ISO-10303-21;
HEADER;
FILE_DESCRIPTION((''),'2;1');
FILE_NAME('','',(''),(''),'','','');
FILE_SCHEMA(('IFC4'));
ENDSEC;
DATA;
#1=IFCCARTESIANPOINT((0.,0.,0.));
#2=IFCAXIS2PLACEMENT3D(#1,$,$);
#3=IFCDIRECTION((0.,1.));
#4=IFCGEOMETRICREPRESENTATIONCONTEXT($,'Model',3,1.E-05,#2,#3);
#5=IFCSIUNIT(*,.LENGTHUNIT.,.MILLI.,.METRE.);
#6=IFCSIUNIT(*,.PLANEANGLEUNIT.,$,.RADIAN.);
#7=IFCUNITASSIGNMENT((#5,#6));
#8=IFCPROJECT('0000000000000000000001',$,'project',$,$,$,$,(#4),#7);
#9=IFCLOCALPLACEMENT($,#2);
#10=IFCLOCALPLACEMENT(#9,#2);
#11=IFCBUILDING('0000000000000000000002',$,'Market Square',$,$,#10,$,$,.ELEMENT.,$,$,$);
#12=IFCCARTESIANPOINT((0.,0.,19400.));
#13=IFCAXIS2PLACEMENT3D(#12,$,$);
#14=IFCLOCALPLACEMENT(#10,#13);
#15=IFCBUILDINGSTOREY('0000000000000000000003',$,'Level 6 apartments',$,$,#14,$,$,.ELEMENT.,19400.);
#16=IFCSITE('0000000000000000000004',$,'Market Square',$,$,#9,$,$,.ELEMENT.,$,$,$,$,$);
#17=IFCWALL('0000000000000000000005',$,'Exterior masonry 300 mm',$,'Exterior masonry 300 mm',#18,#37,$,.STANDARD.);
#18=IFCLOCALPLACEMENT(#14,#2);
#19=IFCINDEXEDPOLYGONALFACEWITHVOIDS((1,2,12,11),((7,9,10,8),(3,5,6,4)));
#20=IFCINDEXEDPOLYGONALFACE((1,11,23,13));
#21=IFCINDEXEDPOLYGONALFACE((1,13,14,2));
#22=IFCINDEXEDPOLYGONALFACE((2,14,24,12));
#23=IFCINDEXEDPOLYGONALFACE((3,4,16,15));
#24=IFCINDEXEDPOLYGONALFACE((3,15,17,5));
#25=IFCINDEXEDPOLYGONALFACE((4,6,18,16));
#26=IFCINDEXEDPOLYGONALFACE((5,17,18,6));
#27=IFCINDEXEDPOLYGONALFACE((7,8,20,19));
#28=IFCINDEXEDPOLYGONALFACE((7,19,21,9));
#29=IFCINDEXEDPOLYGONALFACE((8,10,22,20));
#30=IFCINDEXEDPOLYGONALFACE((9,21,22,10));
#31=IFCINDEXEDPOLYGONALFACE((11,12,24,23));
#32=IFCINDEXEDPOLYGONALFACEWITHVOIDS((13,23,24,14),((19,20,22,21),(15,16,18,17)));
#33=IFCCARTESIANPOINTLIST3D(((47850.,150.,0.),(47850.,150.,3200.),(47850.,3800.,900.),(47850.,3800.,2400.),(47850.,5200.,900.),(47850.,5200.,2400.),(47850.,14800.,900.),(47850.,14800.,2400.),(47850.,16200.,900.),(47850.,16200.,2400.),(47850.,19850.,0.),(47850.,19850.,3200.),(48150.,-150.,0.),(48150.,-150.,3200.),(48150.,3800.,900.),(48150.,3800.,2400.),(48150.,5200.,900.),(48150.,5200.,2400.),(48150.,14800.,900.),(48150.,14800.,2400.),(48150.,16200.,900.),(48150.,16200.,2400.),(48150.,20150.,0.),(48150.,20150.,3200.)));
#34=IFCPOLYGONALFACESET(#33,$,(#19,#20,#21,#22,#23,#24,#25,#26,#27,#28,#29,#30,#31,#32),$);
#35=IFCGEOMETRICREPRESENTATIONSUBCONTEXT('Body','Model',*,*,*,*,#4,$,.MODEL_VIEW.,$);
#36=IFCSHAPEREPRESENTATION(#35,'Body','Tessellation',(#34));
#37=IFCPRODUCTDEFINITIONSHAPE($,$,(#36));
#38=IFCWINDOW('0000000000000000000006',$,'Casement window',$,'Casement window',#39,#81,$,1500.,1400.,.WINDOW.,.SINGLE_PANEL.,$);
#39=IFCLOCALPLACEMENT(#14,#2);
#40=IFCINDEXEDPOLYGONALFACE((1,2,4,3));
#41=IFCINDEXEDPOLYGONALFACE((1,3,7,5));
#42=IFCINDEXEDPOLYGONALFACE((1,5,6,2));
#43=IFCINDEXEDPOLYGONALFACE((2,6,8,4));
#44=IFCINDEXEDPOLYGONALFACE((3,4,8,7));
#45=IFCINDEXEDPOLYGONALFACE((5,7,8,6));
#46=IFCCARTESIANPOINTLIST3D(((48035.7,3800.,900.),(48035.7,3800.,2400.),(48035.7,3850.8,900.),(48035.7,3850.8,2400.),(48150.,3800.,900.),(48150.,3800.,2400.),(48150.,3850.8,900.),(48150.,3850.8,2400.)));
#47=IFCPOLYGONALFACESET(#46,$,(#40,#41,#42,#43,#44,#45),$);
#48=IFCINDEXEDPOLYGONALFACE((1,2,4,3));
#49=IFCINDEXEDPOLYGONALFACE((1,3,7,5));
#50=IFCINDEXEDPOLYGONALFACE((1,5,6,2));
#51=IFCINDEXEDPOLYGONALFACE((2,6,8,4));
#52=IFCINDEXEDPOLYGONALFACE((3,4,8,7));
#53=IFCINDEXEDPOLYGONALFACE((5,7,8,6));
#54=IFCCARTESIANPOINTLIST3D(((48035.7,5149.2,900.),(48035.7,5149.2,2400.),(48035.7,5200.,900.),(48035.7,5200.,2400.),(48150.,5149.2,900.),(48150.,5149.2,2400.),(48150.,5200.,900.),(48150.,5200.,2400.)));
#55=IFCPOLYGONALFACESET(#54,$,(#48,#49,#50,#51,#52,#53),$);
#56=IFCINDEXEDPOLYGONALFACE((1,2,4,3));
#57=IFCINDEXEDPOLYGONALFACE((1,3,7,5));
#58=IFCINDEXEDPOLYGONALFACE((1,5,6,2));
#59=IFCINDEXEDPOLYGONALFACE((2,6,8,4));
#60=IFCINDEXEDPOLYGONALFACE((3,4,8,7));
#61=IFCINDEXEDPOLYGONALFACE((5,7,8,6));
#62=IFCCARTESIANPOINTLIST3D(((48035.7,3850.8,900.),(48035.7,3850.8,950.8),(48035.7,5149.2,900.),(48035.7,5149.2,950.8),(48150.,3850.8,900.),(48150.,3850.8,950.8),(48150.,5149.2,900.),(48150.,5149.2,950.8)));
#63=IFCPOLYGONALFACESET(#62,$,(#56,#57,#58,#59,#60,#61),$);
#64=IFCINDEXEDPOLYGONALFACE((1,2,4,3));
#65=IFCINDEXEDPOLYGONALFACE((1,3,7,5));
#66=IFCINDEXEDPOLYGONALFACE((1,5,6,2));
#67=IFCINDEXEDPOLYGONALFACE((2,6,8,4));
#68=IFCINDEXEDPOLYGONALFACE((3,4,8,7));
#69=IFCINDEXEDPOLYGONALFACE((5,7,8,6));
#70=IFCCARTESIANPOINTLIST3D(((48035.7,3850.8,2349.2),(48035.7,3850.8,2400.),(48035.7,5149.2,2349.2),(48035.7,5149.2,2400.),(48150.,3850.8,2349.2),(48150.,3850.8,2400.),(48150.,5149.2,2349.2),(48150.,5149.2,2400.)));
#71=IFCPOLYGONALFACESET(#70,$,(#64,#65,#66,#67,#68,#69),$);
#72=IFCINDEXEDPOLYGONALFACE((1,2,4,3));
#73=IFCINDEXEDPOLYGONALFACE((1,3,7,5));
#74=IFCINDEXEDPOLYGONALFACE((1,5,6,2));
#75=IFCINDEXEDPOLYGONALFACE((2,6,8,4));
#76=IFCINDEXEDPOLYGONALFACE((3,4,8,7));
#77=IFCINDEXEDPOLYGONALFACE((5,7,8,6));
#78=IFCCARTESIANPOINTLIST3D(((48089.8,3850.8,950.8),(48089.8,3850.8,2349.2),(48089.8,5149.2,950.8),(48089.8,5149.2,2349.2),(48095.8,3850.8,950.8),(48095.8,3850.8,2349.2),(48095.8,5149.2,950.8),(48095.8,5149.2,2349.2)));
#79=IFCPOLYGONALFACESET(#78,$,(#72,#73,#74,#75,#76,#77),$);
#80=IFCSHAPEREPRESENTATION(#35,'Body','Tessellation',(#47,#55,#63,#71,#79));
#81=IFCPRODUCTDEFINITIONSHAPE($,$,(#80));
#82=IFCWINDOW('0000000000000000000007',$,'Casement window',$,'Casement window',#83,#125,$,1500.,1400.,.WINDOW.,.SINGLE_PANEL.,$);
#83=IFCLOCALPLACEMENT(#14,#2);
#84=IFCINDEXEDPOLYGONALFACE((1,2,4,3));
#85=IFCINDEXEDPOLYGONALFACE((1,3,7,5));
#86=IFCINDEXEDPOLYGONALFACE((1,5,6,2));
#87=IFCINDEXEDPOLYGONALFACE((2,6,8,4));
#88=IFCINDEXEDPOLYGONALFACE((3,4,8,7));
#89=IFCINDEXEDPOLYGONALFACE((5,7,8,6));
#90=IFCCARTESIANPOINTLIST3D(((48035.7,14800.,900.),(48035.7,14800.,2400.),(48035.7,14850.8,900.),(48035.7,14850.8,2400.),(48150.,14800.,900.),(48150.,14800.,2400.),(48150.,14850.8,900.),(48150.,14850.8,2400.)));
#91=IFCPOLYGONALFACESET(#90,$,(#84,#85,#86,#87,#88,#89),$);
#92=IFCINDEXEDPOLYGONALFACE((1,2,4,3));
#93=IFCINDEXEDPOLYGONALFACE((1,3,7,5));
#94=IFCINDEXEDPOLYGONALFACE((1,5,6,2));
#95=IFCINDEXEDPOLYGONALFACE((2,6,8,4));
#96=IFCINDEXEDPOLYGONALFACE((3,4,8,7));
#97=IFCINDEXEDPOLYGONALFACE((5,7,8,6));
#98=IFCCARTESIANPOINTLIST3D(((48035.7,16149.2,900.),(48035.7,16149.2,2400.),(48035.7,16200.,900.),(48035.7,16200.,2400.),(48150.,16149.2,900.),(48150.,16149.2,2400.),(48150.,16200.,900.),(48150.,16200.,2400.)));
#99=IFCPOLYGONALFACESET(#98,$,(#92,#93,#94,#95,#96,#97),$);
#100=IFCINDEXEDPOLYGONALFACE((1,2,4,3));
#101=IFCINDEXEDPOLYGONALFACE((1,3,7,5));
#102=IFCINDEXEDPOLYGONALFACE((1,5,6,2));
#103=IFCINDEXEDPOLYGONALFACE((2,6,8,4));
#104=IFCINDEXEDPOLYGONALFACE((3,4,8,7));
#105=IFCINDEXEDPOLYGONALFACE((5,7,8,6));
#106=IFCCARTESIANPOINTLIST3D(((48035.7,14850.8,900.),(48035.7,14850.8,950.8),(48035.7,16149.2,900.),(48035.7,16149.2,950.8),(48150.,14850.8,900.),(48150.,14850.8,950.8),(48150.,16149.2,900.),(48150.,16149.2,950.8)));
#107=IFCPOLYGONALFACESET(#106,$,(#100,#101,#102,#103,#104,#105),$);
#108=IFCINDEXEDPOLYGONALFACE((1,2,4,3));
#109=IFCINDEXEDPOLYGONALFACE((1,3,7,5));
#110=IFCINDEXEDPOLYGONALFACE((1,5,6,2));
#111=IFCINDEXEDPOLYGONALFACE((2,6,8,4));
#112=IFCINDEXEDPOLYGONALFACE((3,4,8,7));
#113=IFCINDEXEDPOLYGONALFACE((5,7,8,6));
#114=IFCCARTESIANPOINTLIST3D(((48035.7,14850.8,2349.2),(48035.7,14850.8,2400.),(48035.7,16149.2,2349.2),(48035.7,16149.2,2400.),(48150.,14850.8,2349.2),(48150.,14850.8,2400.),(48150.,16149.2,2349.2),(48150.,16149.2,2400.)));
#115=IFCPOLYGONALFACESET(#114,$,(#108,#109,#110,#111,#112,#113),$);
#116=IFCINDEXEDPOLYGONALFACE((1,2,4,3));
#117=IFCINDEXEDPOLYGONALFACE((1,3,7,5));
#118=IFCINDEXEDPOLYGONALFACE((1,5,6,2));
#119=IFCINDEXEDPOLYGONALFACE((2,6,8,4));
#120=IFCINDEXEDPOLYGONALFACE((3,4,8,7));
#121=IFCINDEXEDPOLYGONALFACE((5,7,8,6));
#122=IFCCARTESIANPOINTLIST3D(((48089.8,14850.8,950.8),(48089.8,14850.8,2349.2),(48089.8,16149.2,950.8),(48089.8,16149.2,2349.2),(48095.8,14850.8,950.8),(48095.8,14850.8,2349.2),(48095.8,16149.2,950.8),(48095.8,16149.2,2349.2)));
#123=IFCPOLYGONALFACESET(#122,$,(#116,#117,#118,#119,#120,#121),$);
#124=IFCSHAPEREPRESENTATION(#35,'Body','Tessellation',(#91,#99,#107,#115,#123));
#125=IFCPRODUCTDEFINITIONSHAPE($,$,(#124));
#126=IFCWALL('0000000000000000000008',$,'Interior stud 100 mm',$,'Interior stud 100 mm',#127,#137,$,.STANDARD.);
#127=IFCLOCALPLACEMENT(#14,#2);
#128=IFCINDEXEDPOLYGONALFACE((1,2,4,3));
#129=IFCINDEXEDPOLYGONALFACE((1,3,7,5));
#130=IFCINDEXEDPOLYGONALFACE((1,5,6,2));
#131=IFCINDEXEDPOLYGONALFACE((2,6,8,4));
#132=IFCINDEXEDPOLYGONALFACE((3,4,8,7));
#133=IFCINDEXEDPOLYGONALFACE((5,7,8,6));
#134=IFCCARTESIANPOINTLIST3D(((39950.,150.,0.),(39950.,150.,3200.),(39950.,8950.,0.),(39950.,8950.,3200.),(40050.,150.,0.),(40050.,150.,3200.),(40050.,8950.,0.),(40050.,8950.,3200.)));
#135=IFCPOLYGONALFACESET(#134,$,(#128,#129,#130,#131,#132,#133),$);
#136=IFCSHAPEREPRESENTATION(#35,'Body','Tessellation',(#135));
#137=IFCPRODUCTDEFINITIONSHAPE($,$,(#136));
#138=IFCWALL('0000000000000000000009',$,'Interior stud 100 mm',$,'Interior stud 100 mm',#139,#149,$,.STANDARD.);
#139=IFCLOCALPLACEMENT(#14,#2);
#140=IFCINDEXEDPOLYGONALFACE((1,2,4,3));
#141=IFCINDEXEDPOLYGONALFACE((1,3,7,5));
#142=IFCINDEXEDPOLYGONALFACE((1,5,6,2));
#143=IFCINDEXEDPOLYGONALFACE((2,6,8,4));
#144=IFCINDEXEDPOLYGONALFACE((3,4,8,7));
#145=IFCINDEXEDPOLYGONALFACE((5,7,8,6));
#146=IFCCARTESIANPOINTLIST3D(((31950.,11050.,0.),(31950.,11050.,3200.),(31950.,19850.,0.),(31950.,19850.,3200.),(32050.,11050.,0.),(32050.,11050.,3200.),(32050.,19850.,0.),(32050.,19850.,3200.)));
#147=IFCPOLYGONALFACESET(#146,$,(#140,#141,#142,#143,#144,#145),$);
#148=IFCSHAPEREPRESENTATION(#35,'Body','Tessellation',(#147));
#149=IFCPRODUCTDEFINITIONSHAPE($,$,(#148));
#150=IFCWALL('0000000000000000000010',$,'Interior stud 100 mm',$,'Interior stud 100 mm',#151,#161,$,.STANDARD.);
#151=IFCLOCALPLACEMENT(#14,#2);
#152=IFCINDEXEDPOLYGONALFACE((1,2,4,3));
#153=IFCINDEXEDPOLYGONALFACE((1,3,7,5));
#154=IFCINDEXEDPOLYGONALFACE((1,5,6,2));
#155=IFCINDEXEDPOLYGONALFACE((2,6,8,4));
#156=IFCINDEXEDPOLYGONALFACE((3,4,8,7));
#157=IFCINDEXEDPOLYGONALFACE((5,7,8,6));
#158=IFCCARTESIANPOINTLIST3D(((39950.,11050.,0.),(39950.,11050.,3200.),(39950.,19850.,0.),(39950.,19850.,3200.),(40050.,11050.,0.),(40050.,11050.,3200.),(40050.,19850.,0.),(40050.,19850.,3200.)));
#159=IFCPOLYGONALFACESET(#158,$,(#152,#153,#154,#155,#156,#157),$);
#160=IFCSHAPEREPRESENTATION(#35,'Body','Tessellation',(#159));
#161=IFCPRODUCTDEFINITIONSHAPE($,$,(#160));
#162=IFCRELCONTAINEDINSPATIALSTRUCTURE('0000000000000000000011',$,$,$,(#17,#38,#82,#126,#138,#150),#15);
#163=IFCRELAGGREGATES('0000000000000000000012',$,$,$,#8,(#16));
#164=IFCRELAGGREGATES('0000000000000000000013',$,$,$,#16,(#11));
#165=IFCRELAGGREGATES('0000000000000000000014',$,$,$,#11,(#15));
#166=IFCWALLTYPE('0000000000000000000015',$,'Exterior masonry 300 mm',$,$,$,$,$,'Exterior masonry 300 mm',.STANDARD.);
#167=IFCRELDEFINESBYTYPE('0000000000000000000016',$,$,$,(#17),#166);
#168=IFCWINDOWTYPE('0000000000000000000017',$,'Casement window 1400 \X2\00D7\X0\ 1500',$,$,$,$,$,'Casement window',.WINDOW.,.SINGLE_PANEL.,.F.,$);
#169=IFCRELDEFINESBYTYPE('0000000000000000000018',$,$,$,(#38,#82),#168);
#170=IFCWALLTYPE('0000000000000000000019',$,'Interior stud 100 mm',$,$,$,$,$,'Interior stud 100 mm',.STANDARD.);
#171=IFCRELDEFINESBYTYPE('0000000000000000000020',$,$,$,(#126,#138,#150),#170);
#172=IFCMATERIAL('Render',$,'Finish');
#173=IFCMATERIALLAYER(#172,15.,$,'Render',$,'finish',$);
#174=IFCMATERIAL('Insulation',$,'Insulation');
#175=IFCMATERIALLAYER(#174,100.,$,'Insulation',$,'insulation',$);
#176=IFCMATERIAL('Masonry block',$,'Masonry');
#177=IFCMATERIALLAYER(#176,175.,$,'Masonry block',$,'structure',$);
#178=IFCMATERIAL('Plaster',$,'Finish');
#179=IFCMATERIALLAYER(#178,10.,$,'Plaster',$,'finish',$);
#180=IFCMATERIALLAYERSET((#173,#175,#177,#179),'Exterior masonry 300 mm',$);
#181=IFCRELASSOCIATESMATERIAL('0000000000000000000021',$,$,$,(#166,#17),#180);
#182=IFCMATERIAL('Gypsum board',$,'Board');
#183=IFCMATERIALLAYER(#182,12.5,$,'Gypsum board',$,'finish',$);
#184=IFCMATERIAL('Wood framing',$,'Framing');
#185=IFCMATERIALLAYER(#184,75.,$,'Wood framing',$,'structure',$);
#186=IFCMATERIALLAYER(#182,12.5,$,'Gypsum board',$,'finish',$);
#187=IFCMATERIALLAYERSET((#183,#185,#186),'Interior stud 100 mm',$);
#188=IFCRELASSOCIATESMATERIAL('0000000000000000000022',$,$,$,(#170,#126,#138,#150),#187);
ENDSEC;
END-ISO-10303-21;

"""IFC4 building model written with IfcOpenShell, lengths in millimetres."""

from ifc_helpers import new_model, si_unit, direction, frame, origin, origin_with_axes, place, context, subcontext, project, spatial, polyline, outline, extrude, material, layer, layer_set, layer_usage, type_object, element, fill, save


model = new_model("IFC4")

# Units and contexts
model_context = context("Model", 3, precision=1e-05, world=origin(), true_north=direction((0.0, 1.0)))
body_context = subcontext(model_context, "Body", "Model", "MODEL_VIEW")
ifc_project = project(units=[si_unit("LENGTHUNIT", "METRE", prefix="MILLI"), si_unit("PLANEANGLEUNIT", "RADIAN")], contexts=[model_context])

# Site, building, storey
site_placement = place(None, origin())
site = spatial("IfcSite", under=ifc_project, at=site_placement, Name="Market Square", CompositionType="ELEMENT")
building_placement = place(site_placement, origin())
building = spatial("IfcBuilding", under=site, at=building_placement, Name="Market Square", CompositionType="ELEMENT")
storey_placement = place(building_placement, frame((0.0, 0.0, 19400.0)))
storey = spatial("IfcBuildingStorey", under=building, at=storey_placement, Name="Level 6 apartments", CompositionType="ELEMENT", Elevation=19400.0)

# Wall, openings, windows
ifc_material_1 = material(Name="Render", Category="Finish")
ifc_layer_1 = layer(ifc_material_1, 15.0, Name="Render", Category="finish")
ifc_material_2 = material(Name="Insulation", Category="Insulation")
ifc_layer_2 = layer(ifc_material_2, 100.0, Name="Insulation", Category="insulation")
ifc_material_3 = material(Name="Masonry block", Category="Masonry")
ifc_layer_3 = layer(ifc_material_3, 175.0, Name="Masonry block", Category="structure")
ifc_material_4 = material(Name="Plaster", Category="Finish")
ifc_layer_4 = layer(ifc_material_4, 10.0, Name="Plaster", Category="finish")
ifc_layer_set_1 = layer_set([ifc_layer_1, ifc_layer_2, ifc_layer_3, ifc_layer_4], Name="Exterior masonry 300 mm")
ifc_layer_usage_1 = layer_usage(ifc_layer_set_1, "AXIS2", "POSITIVE", -150.0)
wall_type_1 = type_object("IfcWallType", Name="Exterior masonry 300 mm", ElementType="Exterior masonry 300 mm", PredefinedType="STANDARD", material=ifc_layer_set_1)
wall_1_placement = place(storey_placement, frame((48000.0, 0.0, 0.0), z_axis=(0.0, 0.0, 1.0), x_axis=(0.0, 1.0, 0.0)))
wall_1 = element("IfcWall", 1, at=wall_1_placement, inside=storey, type_object=wall_type_1, material=ifc_layer_usage_1, Name="Exterior masonry 300 mm", ObjectType="Exterior masonry 300 mm", PredefinedType="STANDARD", context=body_context, shape_type="SweptSolid", body=[
    extrude(outline(polyline([(-150.0, -150.0), (20150.0, -150.0), (19850.0, 150.0), (150.0, 150.0), (-150.0, -150.0)])), origin(), (0.0, 0.0, 1.0), 3200.0),
])
opening_1_placement = place(wall_1_placement, frame((3800.0, 0.0, 900.0), z_axis=(0.0, 0.0, 1.0), x_axis=(1.0, 0.0, 0.0)))
opening_1 = element("IfcOpeningElement", 2, at=opening_1_placement, cuts=wall_1, PredefinedType="OPENING", context=body_context, shape_type="SweptSolid", body=[
    extrude(outline(polyline([(0.0, -160.0), (1400.0, -160.0), (1400.0, 160.0), (0.0, 160.0), (0.0, -160.0)])), origin(), (0.0, 0.0, 1.0), 1500.0),
])
opening_2_placement = place(wall_1_placement, frame((14800.0, 0.0, 900.0), z_axis=(0.0, 0.0, 1.0), x_axis=(1.0, 0.0, 0.0)))
opening_2 = element("IfcOpeningElement", 3, at=opening_2_placement, cuts=wall_1, PredefinedType="OPENING", context=body_context, shape_type="SweptSolid", body=[
    extrude(outline(polyline([(0.0, -160.0), (1400.0, -160.0), (1400.0, 160.0), (0.0, 160.0), (0.0, -160.0)])), origin(), (0.0, 0.0, 1.0), 1500.0),
])
window_type = type_object("IfcWindowType", Name="Casement window 1400 × 1500", ElementType="Casement window", ParameterTakesPrecedence=False, PartitioningType="SINGLE_PANEL", PredefinedType="WINDOW")
window_1_placement = place(opening_1_placement, origin_with_axes())
window_1 = element("IfcWindow", 4, at=window_1_placement, inside=storey, type_object=window_type, Name="Casement window", ObjectType="Casement window", OverallHeight=1500.0, OverallWidth=1400.0, PartitioningType="SINGLE_PANEL", PredefinedType="WINDOW", context=body_context, shape_type="SweptSolid", body=[
    extrude(outline(polyline([(0.0, -150.0), (50.8, -150.0), (50.8, -35.7), (0.0, -35.7), (0.0, -150.0)])), origin(), (0.0, 0.0, 1.0), 1500.0),
    extrude(outline(polyline([(1349.2, -150.0), (1400.0, -150.0), (1400.0, -35.7), (1349.2, -35.7), (1349.2, -150.0)])), origin(), (0.0, 0.0, 1.0), 1500.0),
    extrude(outline(polyline([(50.8, -150.0), (1349.2, -150.0), (1349.2, -35.7), (50.8, -35.7), (50.8, -150.0)])), origin(), (0.0, 0.0, 1.0), 50.8),
    extrude(outline(polyline([(50.8, -150.0), (1349.2, -150.0), (1349.2, -35.7), (50.8, -35.7), (50.8, -150.0)])), frame((0.0, 0.0, 1449.2)), (0.0, 0.0, 1.0), 50.8),
    extrude(outline(polyline([(50.8, -95.8), (1349.2, -95.8), (1349.2, -89.8), (50.8, -89.8), (50.8, -95.8)])), frame((0.0, 0.0, 50.8)), (0.0, 0.0, 1.0), 1398.4),
])
fill(opening_1, window_1)
window_2_placement = place(opening_2_placement, origin_with_axes())
window_2 = element("IfcWindow", 5, at=window_2_placement, inside=storey, type_object=window_type, Name="Casement window", ObjectType="Casement window", OverallHeight=1500.0, OverallWidth=1400.0, PartitioningType="SINGLE_PANEL", PredefinedType="WINDOW", context=body_context, shape_type="SweptSolid", body=[
    extrude(outline(polyline([(0.0, -150.0), (50.8, -150.0), (50.8, -35.7), (0.0, -35.7), (0.0, -150.0)])), origin(), (0.0, 0.0, 1.0), 1500.0),
    extrude(outline(polyline([(1349.2, -150.0), (1400.0, -150.0), (1400.0, -35.7), (1349.2, -35.7), (1349.2, -150.0)])), origin(), (0.0, 0.0, 1.0), 1500.0),
    extrude(outline(polyline([(50.8, -150.0), (1349.2, -150.0), (1349.2, -35.7), (50.8, -35.7), (50.8, -150.0)])), origin(), (0.0, 0.0, 1.0), 50.8),
    extrude(outline(polyline([(50.8, -150.0), (1349.2, -150.0), (1349.2, -35.7), (50.8, -35.7), (50.8, -150.0)])), frame((0.0, 0.0, 1449.2)), (0.0, 0.0, 1.0), 50.8),
    extrude(outline(polyline([(50.8, -95.8), (1349.2, -95.8), (1349.2, -89.8), (50.8, -89.8), (50.8, -95.8)])), frame((0.0, 0.0, 50.8)), (0.0, 0.0, 1.0), 1398.4),
])
fill(opening_2, window_2)

# Walls
ifc_material_5 = material(Name="Gypsum board", Category="Board")
ifc_layer_5 = layer(ifc_material_5, 12.5, Name="Gypsum board", Category="finish")
ifc_material_6 = material(Name="Wood framing", Category="Framing")
ifc_layer_6 = layer(ifc_material_6, 75.0, Name="Wood framing", Category="structure")
ifc_layer_7 = layer(ifc_material_5, 12.5, Name="Gypsum board", Category="finish")
ifc_layer_set_2 = layer_set([ifc_layer_5, ifc_layer_6, ifc_layer_7], Name="Interior stud 100 mm")
ifc_layer_usage_2 = layer_usage(ifc_layer_set_2, "AXIS2", "NEGATIVE", 50.0)
wall_type_2 = type_object("IfcWallType", Name="Interior stud 100 mm", ElementType="Interior stud 100 mm", PredefinedType="STANDARD", material=ifc_layer_set_2)
wall_2_placement = place(storey_placement, frame((40000.0, 0.0, 0.0), z_axis=(0.0, 0.0, 1.0), x_axis=(0.0, 1.0, 0.0)))
element("IfcWall", 6, at=wall_2_placement, inside=storey, type_object=wall_type_2, material=ifc_layer_usage_2, Name="Interior stud 100 mm", ObjectType="Interior stud 100 mm", PredefinedType="STANDARD", context=body_context, shape_type="SweptSolid", body=[
    extrude(outline(polyline([(150.0, -50.0), (8950.0, -50.0), (8950.0, 50.0), (150.0, 50.0), (150.0, -50.0)])), origin(), (0.0, 0.0, 1.0), 3200.0),
])
ifc_layer_usage_3 = layer_usage(ifc_layer_set_2, "AXIS2", "NEGATIVE", 50.0)
wall_3_placement = place(storey_placement, frame((32000.0, 11000.0, 0.0), z_axis=(0.0, 0.0, 1.0), x_axis=(0.0, 1.0, 0.0)))
element("IfcWall", 7, at=wall_3_placement, inside=storey, type_object=wall_type_2, material=ifc_layer_usage_3, Name="Interior stud 100 mm", ObjectType="Interior stud 100 mm", PredefinedType="STANDARD", context=body_context, shape_type="SweptSolid", body=[
    extrude(outline(polyline([(50.0, -50.0), (8850.0, -50.0), (8850.0, 50.0), (50.0, 50.0), (50.0, -50.0)])), origin(), (0.0, 0.0, 1.0), 3200.0),
])
ifc_layer_usage_4 = layer_usage(ifc_layer_set_2, "AXIS2", "NEGATIVE", 50.0)
wall_4_placement = place(storey_placement, frame((40000.0, 11000.0, 0.0), z_axis=(0.0, 0.0, 1.0), x_axis=(0.0, 1.0, 0.0)))
element("IfcWall", 8, at=wall_4_placement, inside=storey, type_object=wall_type_2, material=ifc_layer_usage_4, Name="Interior stud 100 mm", ObjectType="Interior stud 100 mm", PredefinedType="STANDARD", context=body_context, shape_type="SweptSolid", body=[
    extrude(outline(polyline([(50.0, -50.0), (8850.0, -50.0), (8850.0, 50.0), (50.0, 50.0), (50.0, -50.0)])), origin(), (0.0, 0.0, 1.0), 3200.0),
])

save(model, "model.ifc")
